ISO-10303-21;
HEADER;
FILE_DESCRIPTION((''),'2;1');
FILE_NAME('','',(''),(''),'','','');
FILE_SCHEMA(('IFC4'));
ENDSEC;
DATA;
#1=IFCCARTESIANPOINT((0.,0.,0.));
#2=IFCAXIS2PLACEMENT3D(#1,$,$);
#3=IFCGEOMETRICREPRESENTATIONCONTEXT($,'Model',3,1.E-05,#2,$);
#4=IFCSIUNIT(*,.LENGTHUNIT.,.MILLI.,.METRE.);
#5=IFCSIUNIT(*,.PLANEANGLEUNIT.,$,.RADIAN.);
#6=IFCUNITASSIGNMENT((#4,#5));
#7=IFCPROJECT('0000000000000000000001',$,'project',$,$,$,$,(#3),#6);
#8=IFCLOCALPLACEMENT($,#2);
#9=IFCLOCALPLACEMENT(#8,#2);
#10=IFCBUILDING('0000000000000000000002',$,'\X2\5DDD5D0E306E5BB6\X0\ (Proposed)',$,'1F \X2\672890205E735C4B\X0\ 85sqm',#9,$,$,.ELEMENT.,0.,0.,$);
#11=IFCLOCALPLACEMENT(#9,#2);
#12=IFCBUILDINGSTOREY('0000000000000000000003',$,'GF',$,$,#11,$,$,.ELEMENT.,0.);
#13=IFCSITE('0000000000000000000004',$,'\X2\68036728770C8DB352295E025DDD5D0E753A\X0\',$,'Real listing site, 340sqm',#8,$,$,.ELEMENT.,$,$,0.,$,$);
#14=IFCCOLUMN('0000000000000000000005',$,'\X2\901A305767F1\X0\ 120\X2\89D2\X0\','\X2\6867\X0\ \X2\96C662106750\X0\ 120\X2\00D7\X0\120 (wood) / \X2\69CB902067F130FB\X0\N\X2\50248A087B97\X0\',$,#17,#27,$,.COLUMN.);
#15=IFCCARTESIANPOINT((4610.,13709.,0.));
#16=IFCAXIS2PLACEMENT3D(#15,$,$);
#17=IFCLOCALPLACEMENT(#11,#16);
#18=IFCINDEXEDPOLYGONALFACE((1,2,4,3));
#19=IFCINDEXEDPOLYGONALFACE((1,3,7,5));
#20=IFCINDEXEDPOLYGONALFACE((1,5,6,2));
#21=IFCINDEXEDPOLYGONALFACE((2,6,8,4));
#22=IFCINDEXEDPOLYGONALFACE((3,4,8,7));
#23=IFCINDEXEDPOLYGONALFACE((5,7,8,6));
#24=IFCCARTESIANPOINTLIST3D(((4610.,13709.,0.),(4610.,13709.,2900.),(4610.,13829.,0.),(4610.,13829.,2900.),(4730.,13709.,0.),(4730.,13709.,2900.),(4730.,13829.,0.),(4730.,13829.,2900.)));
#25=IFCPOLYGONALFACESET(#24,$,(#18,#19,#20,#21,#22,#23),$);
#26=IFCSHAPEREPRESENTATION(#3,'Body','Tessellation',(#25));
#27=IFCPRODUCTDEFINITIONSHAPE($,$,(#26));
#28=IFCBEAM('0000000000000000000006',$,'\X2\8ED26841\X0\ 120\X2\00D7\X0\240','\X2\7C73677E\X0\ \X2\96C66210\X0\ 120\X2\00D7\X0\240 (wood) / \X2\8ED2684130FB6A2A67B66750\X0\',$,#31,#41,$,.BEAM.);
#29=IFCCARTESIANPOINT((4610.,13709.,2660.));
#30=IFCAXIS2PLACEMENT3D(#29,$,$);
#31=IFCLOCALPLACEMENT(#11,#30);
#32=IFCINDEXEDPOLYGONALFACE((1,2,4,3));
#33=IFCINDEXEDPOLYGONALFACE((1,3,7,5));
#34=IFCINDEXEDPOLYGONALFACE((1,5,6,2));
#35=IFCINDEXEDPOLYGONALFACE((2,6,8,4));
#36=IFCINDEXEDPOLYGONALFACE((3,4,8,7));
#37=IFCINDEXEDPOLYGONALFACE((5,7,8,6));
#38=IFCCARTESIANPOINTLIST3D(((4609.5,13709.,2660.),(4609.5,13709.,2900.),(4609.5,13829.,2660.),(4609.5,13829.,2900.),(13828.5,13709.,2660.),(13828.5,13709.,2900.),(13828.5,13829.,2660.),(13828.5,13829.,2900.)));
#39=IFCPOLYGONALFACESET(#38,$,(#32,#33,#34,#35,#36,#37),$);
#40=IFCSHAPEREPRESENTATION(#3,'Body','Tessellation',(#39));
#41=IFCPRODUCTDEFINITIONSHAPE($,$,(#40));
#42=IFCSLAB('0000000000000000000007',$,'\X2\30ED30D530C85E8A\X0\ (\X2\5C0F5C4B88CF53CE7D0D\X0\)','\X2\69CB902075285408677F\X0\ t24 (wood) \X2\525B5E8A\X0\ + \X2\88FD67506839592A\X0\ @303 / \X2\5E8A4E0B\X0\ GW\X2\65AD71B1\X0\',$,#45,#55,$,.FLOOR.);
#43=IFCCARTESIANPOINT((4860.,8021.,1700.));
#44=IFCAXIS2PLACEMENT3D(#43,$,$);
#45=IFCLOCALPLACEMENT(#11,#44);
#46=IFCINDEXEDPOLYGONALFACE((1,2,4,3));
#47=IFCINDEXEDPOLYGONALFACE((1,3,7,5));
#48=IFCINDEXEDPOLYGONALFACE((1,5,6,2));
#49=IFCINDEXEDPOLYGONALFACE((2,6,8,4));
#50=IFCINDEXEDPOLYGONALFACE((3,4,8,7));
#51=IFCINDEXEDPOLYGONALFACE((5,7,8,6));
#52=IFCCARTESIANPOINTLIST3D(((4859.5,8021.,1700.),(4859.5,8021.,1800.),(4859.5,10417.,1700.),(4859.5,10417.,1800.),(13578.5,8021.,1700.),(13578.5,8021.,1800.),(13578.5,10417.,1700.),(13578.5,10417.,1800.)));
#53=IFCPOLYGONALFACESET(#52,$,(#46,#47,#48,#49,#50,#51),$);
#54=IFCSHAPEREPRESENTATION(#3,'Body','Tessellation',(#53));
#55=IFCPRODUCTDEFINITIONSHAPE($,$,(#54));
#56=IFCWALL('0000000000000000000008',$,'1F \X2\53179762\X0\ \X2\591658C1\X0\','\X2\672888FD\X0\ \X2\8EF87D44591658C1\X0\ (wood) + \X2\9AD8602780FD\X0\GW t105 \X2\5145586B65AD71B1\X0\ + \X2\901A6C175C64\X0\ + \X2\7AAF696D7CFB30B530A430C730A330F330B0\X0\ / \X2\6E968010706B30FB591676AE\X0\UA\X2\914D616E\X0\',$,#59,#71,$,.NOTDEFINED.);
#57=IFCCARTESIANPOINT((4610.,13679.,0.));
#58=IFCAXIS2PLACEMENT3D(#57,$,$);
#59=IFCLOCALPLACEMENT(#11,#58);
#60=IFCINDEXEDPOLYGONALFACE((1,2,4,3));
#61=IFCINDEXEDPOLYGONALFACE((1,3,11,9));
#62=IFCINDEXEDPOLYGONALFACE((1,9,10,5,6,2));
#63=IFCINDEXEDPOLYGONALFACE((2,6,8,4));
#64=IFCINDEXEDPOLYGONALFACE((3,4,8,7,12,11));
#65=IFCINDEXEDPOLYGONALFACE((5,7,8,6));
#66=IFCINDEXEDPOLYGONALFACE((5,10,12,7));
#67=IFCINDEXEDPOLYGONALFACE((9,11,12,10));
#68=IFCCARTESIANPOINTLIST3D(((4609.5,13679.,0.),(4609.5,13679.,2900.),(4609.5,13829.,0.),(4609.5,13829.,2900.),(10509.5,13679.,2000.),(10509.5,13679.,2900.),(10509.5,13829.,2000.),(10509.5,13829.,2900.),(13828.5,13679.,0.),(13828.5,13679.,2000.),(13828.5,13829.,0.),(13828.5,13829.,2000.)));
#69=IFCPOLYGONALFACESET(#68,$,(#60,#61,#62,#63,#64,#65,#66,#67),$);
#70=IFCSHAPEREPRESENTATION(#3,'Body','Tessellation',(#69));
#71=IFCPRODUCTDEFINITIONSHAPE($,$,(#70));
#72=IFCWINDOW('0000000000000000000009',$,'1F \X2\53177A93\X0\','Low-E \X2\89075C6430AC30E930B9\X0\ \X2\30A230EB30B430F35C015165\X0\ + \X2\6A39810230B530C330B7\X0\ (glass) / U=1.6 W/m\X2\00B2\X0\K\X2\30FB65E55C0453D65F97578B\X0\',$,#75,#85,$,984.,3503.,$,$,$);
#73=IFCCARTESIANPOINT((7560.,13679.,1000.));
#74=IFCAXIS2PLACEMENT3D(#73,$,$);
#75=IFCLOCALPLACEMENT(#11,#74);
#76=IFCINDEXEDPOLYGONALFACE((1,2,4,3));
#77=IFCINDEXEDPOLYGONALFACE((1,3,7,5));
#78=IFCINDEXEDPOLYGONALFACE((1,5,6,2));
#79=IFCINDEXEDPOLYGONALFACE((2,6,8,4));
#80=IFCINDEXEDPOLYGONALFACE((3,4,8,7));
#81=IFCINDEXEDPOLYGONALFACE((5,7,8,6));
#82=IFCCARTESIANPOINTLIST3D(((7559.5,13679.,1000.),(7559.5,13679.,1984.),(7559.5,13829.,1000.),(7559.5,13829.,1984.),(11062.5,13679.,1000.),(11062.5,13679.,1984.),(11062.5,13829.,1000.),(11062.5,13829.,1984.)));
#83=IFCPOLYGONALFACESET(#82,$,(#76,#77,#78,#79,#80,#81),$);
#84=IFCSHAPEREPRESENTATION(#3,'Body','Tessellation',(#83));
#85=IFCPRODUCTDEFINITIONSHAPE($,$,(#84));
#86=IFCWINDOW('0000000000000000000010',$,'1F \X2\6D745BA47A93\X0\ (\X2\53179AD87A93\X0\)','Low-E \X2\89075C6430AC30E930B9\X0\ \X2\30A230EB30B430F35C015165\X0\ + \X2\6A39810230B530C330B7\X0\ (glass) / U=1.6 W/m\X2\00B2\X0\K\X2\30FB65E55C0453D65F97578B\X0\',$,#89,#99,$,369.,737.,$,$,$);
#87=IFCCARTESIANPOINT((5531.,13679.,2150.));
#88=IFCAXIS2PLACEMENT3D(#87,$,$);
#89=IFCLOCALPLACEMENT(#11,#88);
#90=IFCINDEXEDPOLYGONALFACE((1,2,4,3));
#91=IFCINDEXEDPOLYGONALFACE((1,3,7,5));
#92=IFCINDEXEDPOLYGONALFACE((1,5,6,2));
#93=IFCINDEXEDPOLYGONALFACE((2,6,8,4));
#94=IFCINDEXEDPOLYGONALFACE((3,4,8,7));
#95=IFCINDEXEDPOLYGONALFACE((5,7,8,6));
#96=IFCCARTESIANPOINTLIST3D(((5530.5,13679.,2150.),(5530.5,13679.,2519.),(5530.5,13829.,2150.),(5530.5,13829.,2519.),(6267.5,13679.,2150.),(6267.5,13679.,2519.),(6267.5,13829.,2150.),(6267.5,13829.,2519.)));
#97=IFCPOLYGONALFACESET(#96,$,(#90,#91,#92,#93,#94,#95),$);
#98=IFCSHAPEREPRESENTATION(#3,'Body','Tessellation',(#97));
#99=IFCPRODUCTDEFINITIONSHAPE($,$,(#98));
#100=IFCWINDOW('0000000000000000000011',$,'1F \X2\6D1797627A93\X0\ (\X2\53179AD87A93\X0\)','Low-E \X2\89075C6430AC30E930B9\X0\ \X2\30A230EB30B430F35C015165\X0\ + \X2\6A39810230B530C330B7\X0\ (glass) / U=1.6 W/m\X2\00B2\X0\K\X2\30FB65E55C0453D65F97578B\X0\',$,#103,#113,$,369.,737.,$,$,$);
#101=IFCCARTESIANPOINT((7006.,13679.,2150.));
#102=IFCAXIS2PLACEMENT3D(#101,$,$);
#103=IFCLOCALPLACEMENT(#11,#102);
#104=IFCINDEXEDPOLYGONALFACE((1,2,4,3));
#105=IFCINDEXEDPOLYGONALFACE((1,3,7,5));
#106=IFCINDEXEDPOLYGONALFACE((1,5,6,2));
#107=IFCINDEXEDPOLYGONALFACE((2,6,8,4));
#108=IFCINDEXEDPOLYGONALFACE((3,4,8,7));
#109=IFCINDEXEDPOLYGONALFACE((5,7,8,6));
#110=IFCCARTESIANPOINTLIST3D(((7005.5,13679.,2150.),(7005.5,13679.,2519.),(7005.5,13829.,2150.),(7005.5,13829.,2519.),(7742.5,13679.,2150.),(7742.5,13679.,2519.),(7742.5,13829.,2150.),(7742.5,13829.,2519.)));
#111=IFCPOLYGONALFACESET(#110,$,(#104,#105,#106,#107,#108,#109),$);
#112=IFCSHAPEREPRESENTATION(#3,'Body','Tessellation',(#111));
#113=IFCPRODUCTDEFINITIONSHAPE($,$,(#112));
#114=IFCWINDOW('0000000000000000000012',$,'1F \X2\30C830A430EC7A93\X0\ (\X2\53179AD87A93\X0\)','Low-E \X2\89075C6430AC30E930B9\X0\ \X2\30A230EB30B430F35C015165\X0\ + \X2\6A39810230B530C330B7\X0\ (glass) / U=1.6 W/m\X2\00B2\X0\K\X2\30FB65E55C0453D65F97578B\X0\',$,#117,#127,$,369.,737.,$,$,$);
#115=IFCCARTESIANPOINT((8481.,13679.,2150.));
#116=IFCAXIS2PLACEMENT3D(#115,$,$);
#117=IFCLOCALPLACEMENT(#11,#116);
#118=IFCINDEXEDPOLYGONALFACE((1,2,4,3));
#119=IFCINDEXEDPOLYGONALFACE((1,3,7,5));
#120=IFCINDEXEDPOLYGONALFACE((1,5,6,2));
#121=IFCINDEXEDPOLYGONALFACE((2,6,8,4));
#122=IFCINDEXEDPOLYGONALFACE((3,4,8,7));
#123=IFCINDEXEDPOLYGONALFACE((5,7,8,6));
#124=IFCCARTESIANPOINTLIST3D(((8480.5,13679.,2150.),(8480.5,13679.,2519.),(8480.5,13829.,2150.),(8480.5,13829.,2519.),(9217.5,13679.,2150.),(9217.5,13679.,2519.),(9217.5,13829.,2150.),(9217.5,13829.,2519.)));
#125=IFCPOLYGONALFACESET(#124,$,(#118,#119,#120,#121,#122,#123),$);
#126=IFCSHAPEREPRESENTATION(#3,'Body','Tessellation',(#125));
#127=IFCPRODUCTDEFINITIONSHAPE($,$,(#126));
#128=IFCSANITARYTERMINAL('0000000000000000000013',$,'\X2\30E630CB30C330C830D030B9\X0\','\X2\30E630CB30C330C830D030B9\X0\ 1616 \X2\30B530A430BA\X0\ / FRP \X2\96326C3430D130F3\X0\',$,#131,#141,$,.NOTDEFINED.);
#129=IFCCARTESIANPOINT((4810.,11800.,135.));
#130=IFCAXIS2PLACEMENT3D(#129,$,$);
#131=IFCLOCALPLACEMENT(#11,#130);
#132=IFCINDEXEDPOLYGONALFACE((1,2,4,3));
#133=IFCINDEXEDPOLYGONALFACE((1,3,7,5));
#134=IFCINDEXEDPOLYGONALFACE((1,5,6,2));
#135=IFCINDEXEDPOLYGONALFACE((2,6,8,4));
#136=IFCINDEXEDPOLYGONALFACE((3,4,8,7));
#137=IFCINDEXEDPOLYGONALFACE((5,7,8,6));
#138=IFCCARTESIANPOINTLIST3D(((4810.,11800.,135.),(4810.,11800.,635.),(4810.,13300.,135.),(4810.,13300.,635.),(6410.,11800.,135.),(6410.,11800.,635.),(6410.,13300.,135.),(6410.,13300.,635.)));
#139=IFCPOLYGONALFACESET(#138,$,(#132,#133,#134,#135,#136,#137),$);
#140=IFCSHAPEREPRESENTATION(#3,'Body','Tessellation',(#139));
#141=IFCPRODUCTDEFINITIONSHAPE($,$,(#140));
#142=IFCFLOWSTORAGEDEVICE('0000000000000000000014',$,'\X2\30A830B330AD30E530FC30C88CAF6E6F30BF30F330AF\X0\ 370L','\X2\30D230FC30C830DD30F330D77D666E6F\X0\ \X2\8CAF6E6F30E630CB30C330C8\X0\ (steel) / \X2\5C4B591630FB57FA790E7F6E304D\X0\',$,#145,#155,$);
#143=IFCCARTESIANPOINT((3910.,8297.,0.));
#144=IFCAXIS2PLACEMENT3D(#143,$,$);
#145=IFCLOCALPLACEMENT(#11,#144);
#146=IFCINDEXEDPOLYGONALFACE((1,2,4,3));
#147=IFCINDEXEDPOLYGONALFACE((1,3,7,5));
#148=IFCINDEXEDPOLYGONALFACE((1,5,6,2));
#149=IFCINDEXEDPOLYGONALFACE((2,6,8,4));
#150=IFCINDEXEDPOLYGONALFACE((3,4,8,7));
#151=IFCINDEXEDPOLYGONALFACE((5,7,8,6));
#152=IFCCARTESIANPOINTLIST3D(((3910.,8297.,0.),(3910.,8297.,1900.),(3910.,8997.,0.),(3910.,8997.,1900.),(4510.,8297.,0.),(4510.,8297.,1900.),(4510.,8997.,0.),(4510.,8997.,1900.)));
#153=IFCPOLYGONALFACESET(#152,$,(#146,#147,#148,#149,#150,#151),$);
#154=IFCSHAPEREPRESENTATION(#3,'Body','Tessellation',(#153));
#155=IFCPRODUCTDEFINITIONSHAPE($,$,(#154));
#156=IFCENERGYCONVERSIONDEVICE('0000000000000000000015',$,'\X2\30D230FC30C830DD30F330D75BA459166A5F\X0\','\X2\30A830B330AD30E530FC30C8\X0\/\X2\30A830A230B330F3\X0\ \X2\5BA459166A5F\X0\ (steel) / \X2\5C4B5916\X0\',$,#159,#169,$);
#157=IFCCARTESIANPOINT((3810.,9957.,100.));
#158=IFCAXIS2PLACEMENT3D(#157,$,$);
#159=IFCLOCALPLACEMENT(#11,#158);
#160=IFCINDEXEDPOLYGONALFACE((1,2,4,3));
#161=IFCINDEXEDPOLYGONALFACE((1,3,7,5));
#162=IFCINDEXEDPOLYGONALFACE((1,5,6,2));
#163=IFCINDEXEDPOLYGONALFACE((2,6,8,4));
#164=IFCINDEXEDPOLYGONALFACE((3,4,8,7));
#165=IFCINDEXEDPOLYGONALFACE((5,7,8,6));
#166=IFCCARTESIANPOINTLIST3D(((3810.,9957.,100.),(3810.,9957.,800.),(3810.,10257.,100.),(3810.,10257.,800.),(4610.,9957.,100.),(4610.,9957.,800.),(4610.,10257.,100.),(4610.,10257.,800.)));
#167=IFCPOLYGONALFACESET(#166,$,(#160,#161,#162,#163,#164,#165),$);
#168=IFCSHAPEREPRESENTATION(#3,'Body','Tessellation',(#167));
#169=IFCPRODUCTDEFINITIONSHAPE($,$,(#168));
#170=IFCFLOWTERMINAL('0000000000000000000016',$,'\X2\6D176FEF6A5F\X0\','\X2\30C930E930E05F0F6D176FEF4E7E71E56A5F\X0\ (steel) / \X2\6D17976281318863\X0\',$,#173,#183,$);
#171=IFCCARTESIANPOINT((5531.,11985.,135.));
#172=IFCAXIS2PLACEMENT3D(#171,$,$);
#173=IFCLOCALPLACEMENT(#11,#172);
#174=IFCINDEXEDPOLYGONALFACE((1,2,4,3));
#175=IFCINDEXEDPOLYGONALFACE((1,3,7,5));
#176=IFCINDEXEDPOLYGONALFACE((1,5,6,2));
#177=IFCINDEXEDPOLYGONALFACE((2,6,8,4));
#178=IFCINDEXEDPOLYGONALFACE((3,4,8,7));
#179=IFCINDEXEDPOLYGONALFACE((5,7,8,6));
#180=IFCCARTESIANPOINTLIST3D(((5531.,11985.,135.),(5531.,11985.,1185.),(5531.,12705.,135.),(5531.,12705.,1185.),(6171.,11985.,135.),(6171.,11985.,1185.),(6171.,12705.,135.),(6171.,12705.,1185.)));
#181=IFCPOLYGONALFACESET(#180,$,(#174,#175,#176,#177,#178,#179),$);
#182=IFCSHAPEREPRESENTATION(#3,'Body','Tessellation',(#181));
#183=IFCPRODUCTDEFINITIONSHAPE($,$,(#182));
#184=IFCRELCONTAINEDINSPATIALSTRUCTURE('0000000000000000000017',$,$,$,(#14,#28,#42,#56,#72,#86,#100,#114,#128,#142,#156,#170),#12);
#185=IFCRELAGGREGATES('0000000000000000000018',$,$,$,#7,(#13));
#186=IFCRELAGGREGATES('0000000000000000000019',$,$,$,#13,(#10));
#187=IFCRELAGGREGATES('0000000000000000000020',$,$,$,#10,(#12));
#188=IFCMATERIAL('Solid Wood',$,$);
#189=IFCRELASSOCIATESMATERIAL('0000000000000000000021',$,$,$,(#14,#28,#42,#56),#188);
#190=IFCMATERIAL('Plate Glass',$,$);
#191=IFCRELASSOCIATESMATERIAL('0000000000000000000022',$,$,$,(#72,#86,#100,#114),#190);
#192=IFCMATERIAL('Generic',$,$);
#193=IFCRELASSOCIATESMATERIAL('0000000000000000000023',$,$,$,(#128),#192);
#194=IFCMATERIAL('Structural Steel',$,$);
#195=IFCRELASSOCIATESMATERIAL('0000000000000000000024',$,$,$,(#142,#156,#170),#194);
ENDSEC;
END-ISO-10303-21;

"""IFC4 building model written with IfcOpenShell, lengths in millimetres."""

from ifc_helpers import new_model, si_unit, frame, frame_2d, origin, place, context, project, spatial, rectangle, extrude, material, element, fill, save


model = new_model("IFC4")

# Units and contexts
model_context = context("Model", 3, precision=1e-05, world=origin())
ifc_project = project(units=[si_unit("LENGTHUNIT", "METRE", prefix="MILLI"), si_unit("PLANEANGLEUNIT", "RADIAN")], contexts=[model_context])

# Site, building, storey
site_placement = place(None, origin())
site = spatial("IfcSite", under=ifc_project, at=site_placement, Name="栃木県足利市川崎町", ObjectType="Real listing site, 340sqm", CompositionType="ELEMENT", RefElevation=0.0)
building_placement = place(site_placement, origin())
building = spatial("IfcBuilding", under=site, at=building_placement, Name="川崎の家 (Proposed)", ObjectType="1F 木造平屋 85sqm", CompositionType="ELEMENT", ElevationOfRefHeight=0.0, ElevationOfTerrain=0.0)
storey_placement = place(building_placement, origin())
storey = spatial("IfcBuildingStorey", under=building, at=storey_placement, Name="GF", CompositionType="ELEMENT", Elevation=0.0)

# Column
ifc_material_1 = material(Name="Solid Wood")
column_1_placement = place(storey_placement, frame((4610.0, 13709.0, 0.0)))
element("IfcColumn", 1, at=column_1_placement, inside=storey, material=ifc_material_1, Name="通し柱 120角", Description="桧 集成材 120×120 (wood) / 構造柱・N値計算", PredefinedType="COLUMN", context=model_context, shape_type="SweptSolid", body=[
    extrude(rectangle(XDim=120.0, YDim=120.0, at=frame_2d((60.0, 60.0))), frame((4610.0, 13709.0, 0.0)), (0.0, 0.0, 1.0), 2900.0),
])

# Beam
beam_1_placement = place(storey_placement, frame((4610.0, 13709.0, 2660.0)))
element("IfcBeam", 2, at=beam_1_placement, inside=storey, material=ifc_material_1, Name="軒桁 120×240", Description="米松 集成 120×240 (wood) / 軒桁・横架材", PredefinedType="BEAM", context=model_context, shape_type="SweptSolid", body=[
    extrude(rectangle(XDim=9219.0, YDim=120.0, at=frame_2d((4609.0, 60.0))), frame((4610.0, 13709.0, 2660.0)), (0.0, 0.0, 1.0), 240.0),
])

# Slab
slab_placement = place(storey_placement, frame((4860.0, 8021.0, 1700.0)))
element("IfcSlab", 3, at=slab_placement, inside=storey, material=ifc_material_1, Name="ロフト床 (小屋裏収納)", Description="構造用合板 t24 (wood) 剛床 + 製材根太 @303 / 床下 GW断熱", PredefinedType="FLOOR", context=model_context, shape_type="SweptSolid", body=[
    extrude(rectangle(XDim=8719.0, YDim=2396.0, at=frame_2d((4359.0, 1198.0))), frame((4860.0, 8021.0, 1700.0)), (0.0, 0.0, 1.0), 100.0),
])

# Wall, openings, windows
wall_1_placement = place(storey_placement, frame((4610.0, 13679.0, 0.0)))
wall_1 = element("IfcWall", 4, at=wall_1_placement, inside=storey, material=ifc_material_1, Name="1F 北面 外壁", Description="木製 軸組外壁 (wood) + 高性能GW t105 充填断熱 + 通気層 + 窯業系サイディング / 準耐火・外皮UA配慮", PredefinedType="NOTDEFINED", context=model_context, shape_type="SweptSolid", body=[
    extrude(rectangle(XDim=9219.0, YDim=150.0, at=frame_2d((4609.0, 75.0))), frame((4610.0, 13679.0, 0.0)), (0.0, 0.0, 1.0), 2900.0),
])
opening_1_placement = place(storey_placement, frame((7560.0, 13679.0, 1000.0)))
opening_1 = element("IfcOpeningElement", 5, at=opening_1_placement, cuts=wall_1, PredefinedType="NOTDEFINED", context=model_context, shape_type="SweptSolid", body=[
    extrude(rectangle(XDim=3503.0, YDim=150.0, at=frame_2d((1751.0, 75.0))), frame((7560.0, 13679.0, 1000.0)), (0.0, 0.0, 1.0), 984.0),
])
opening_2_placement = place(storey_placement, frame((5531.0, 13679.0, 2150.0)))
opening_2 = element("IfcOpeningElement", 6, at=opening_2_placement, cuts=wall_1, PredefinedType="NOTDEFINED", context=model_context, shape_type="SweptSolid", body=[
    extrude(rectangle(XDim=737.0, YDim=150.0, at=frame_2d((368.0, 75.0))), frame((5531.0, 13679.0, 2150.0)), (0.0, 0.0, 1.0), 369.0),
])
opening_3_placement = place(storey_placement, frame((7006.0, 13679.0, 2150.0)))
opening_3 = element("IfcOpeningElement", 7, at=opening_3_placement, cuts=wall_1, PredefinedType="NOTDEFINED", context=model_context, shape_type="SweptSolid", body=[
    extrude(rectangle(XDim=737.0, YDim=150.0, at=frame_2d((368.0, 75.0))), frame((7006.0, 13679.0, 2150.0)), (0.0, 0.0, 1.0), 369.0),
])
opening_4_placement = place(storey_placement, frame((8481.0, 13679.0, 2150.0)))
opening_4 = element("IfcOpeningElement", 8, at=opening_4_placement, cuts=wall_1, PredefinedType="NOTDEFINED", context=model_context, shape_type="SweptSolid", body=[
    extrude(rectangle(XDim=737.0, YDim=150.0, at=frame_2d((368.0, 75.0))), frame((8481.0, 13679.0, 2150.0)), (0.0, 0.0, 1.0), 369.0),
])
ifc_material_2 = material(Name="Plate Glass")
window_1_placement = place(storey_placement, frame((7560.0, 13679.0, 1000.0)))
window_1 = element("IfcWindow", 9, at=window_1_placement, inside=storey, material=ifc_material_2, Name="1F 北窓", Description="Low-E 複層ガラス アルゴン封入 + 樹脂サッシ (glass) / U=1.6 W/m²K・日射取得型", OverallHeight=984.0, OverallWidth=3503.0, context=model_context, shape_type="SweptSolid", body=[
    extrude(rectangle(XDim=3503.0, YDim=150.0, at=frame_2d((1751.0, 75.0))), frame((7560.0, 13679.0, 1000.0)), (0.0, 0.0, 1.0), 984.0),
])
fill(opening_1, window_1)
window_2_placement = place(storey_placement, frame((5531.0, 13679.0, 2150.0)))
window_2 = element("IfcWindow", 10, at=window_2_placement, inside=storey, material=ifc_material_2, Name="1F 浴室窓 (北高窓)", Description="Low-E 複層ガラス アルゴン封入 + 樹脂サッシ (glass) / U=1.6 W/m²K・日射取得型", OverallHeight=369.0, OverallWidth=737.0, context=model_context, shape_type="SweptSolid", body=[
    extrude(rectangle(XDim=737.0, YDim=150.0, at=frame_2d((368.0, 75.0))), frame((5531.0, 13679.0, 2150.0)), (0.0, 0.0, 1.0), 369.0),
])
fill(opening_2, window_2)
window_3_placement = place(storey_placement, frame((7006.0, 13679.0, 2150.0)))
window_3 = element("IfcWindow", 11, at=window_3_placement, inside=storey, material=ifc_material_2, Name="1F 洗面窓 (北高窓)", Description="Low-E 複層ガラス アルゴン封入 + 樹脂サッシ (glass) / U=1.6 W/m²K・日射取得型", OverallHeight=369.0, OverallWidth=737.0, context=model_context, shape_type="SweptSolid", body=[
    extrude(rectangle(XDim=737.0, YDim=150.0, at=frame_2d((368.0, 75.0))), frame((7006.0, 13679.0, 2150.0)), (0.0, 0.0, 1.0), 369.0),
])
fill(opening_3, window_3)
window_4_placement = place(storey_placement, frame((8481.0, 13679.0, 2150.0)))
window_4 = element("IfcWindow", 12, at=window_4_placement, inside=storey, material=ifc_material_2, Name="1F トイレ窓 (北高窓)", Description="Low-E 複層ガラス アルゴン封入 + 樹脂サッシ (glass) / U=1.6 W/m²K・日射取得型", OverallHeight=369.0, OverallWidth=737.0, context=model_context, shape_type="SweptSolid", body=[
    extrude(rectangle(XDim=737.0, YDim=150.0, at=frame_2d((368.0, 75.0))), frame((8481.0, 13679.0, 2150.0)), (0.0, 0.0, 1.0), 369.0),
])
fill(opening_4, window_4)

# Shared definitions
ifc_material_3 = material(Name="Structural Steel")

# Sanitary terminal
ifc_material_4 = material(Name="Generic")
sanitary_terminal_placement = place(storey_placement, frame((4810.0, 11800.0, 135.0)))
element("IfcSanitaryTerminal", 13, at=sanitary_terminal_placement, inside=storey, material=ifc_material_4, Name="ユニットバス", Description="ユニットバス 1616 サイズ / FRP 防水パン", PredefinedType="NOTDEFINED", context=model_context, shape_type="SweptSolid", body=[
    extrude(rectangle(XDim=1600.0, YDim=1500.0, at=frame_2d((800.0, 750.0))), frame((4810.0, 11800.0, 135.0)), (0.0, 0.0, 1.0), 500.0),
])

# Flow storage device
flow_storage_device_placement = place(storey_placement, frame((3910.0, 8297.0, 0.0)))
element("IfcFlowStorageDevice", 14, at=flow_storage_device_placement, inside=storey, material=ifc_material_3, Name="エコキュート貯湯タンク 370L", Description="ヒートポンプ給湯 貯湯ユニット (steel) / 屋外・基礎置き", context=model_context, shape_type="SweptSolid", body=[
    extrude(rectangle(XDim=600.0, YDim=700.0, at=frame_2d((300.0, 350.0))), frame((3910.0, 8297.0, 0.0)), (0.0, 0.0, 1.0), 1900.0),
])

# Energy conversion device
energy_conversion_device_placement = place(storey_placement, frame((3810.0, 9957.0, 100.0)))
element("IfcEnergyConversionDevice", 15, at=energy_conversion_device_placement, inside=storey, material=ifc_material_3, Name="ヒートポンプ室外機", Description="エコキュート/エアコン 室外機 (steel) / 屋外", context=model_context, shape_type="SweptSolid", body=[
    extrude(rectangle(XDim=800.0, YDim=300.0, at=frame_2d((400.0, 150.0))), frame((3810.0, 9957.0, 100.0)), (0.0, 0.0, 1.0), 700.0),
])

# Flow terminal
flow_terminal_placement = place(storey_placement, frame((5531.0, 11985.0, 135.0)))
element("IfcFlowTerminal", 16, at=flow_terminal_placement, inside=storey, material=ifc_material_3, Name="洗濯機", Description="ドラム式洗濯乾燥機 (steel) / 洗面脱衣", context=model_context, shape_type="SweptSolid", body=[
    extrude(rectangle(XDim=640.0, YDim=720.0, at=frame_2d((320.0, 360.0))), frame((5531.0, 11985.0, 135.0)), (0.0, 0.0, 1.0), 1050.0),
])

save(model, "model.ifc")
